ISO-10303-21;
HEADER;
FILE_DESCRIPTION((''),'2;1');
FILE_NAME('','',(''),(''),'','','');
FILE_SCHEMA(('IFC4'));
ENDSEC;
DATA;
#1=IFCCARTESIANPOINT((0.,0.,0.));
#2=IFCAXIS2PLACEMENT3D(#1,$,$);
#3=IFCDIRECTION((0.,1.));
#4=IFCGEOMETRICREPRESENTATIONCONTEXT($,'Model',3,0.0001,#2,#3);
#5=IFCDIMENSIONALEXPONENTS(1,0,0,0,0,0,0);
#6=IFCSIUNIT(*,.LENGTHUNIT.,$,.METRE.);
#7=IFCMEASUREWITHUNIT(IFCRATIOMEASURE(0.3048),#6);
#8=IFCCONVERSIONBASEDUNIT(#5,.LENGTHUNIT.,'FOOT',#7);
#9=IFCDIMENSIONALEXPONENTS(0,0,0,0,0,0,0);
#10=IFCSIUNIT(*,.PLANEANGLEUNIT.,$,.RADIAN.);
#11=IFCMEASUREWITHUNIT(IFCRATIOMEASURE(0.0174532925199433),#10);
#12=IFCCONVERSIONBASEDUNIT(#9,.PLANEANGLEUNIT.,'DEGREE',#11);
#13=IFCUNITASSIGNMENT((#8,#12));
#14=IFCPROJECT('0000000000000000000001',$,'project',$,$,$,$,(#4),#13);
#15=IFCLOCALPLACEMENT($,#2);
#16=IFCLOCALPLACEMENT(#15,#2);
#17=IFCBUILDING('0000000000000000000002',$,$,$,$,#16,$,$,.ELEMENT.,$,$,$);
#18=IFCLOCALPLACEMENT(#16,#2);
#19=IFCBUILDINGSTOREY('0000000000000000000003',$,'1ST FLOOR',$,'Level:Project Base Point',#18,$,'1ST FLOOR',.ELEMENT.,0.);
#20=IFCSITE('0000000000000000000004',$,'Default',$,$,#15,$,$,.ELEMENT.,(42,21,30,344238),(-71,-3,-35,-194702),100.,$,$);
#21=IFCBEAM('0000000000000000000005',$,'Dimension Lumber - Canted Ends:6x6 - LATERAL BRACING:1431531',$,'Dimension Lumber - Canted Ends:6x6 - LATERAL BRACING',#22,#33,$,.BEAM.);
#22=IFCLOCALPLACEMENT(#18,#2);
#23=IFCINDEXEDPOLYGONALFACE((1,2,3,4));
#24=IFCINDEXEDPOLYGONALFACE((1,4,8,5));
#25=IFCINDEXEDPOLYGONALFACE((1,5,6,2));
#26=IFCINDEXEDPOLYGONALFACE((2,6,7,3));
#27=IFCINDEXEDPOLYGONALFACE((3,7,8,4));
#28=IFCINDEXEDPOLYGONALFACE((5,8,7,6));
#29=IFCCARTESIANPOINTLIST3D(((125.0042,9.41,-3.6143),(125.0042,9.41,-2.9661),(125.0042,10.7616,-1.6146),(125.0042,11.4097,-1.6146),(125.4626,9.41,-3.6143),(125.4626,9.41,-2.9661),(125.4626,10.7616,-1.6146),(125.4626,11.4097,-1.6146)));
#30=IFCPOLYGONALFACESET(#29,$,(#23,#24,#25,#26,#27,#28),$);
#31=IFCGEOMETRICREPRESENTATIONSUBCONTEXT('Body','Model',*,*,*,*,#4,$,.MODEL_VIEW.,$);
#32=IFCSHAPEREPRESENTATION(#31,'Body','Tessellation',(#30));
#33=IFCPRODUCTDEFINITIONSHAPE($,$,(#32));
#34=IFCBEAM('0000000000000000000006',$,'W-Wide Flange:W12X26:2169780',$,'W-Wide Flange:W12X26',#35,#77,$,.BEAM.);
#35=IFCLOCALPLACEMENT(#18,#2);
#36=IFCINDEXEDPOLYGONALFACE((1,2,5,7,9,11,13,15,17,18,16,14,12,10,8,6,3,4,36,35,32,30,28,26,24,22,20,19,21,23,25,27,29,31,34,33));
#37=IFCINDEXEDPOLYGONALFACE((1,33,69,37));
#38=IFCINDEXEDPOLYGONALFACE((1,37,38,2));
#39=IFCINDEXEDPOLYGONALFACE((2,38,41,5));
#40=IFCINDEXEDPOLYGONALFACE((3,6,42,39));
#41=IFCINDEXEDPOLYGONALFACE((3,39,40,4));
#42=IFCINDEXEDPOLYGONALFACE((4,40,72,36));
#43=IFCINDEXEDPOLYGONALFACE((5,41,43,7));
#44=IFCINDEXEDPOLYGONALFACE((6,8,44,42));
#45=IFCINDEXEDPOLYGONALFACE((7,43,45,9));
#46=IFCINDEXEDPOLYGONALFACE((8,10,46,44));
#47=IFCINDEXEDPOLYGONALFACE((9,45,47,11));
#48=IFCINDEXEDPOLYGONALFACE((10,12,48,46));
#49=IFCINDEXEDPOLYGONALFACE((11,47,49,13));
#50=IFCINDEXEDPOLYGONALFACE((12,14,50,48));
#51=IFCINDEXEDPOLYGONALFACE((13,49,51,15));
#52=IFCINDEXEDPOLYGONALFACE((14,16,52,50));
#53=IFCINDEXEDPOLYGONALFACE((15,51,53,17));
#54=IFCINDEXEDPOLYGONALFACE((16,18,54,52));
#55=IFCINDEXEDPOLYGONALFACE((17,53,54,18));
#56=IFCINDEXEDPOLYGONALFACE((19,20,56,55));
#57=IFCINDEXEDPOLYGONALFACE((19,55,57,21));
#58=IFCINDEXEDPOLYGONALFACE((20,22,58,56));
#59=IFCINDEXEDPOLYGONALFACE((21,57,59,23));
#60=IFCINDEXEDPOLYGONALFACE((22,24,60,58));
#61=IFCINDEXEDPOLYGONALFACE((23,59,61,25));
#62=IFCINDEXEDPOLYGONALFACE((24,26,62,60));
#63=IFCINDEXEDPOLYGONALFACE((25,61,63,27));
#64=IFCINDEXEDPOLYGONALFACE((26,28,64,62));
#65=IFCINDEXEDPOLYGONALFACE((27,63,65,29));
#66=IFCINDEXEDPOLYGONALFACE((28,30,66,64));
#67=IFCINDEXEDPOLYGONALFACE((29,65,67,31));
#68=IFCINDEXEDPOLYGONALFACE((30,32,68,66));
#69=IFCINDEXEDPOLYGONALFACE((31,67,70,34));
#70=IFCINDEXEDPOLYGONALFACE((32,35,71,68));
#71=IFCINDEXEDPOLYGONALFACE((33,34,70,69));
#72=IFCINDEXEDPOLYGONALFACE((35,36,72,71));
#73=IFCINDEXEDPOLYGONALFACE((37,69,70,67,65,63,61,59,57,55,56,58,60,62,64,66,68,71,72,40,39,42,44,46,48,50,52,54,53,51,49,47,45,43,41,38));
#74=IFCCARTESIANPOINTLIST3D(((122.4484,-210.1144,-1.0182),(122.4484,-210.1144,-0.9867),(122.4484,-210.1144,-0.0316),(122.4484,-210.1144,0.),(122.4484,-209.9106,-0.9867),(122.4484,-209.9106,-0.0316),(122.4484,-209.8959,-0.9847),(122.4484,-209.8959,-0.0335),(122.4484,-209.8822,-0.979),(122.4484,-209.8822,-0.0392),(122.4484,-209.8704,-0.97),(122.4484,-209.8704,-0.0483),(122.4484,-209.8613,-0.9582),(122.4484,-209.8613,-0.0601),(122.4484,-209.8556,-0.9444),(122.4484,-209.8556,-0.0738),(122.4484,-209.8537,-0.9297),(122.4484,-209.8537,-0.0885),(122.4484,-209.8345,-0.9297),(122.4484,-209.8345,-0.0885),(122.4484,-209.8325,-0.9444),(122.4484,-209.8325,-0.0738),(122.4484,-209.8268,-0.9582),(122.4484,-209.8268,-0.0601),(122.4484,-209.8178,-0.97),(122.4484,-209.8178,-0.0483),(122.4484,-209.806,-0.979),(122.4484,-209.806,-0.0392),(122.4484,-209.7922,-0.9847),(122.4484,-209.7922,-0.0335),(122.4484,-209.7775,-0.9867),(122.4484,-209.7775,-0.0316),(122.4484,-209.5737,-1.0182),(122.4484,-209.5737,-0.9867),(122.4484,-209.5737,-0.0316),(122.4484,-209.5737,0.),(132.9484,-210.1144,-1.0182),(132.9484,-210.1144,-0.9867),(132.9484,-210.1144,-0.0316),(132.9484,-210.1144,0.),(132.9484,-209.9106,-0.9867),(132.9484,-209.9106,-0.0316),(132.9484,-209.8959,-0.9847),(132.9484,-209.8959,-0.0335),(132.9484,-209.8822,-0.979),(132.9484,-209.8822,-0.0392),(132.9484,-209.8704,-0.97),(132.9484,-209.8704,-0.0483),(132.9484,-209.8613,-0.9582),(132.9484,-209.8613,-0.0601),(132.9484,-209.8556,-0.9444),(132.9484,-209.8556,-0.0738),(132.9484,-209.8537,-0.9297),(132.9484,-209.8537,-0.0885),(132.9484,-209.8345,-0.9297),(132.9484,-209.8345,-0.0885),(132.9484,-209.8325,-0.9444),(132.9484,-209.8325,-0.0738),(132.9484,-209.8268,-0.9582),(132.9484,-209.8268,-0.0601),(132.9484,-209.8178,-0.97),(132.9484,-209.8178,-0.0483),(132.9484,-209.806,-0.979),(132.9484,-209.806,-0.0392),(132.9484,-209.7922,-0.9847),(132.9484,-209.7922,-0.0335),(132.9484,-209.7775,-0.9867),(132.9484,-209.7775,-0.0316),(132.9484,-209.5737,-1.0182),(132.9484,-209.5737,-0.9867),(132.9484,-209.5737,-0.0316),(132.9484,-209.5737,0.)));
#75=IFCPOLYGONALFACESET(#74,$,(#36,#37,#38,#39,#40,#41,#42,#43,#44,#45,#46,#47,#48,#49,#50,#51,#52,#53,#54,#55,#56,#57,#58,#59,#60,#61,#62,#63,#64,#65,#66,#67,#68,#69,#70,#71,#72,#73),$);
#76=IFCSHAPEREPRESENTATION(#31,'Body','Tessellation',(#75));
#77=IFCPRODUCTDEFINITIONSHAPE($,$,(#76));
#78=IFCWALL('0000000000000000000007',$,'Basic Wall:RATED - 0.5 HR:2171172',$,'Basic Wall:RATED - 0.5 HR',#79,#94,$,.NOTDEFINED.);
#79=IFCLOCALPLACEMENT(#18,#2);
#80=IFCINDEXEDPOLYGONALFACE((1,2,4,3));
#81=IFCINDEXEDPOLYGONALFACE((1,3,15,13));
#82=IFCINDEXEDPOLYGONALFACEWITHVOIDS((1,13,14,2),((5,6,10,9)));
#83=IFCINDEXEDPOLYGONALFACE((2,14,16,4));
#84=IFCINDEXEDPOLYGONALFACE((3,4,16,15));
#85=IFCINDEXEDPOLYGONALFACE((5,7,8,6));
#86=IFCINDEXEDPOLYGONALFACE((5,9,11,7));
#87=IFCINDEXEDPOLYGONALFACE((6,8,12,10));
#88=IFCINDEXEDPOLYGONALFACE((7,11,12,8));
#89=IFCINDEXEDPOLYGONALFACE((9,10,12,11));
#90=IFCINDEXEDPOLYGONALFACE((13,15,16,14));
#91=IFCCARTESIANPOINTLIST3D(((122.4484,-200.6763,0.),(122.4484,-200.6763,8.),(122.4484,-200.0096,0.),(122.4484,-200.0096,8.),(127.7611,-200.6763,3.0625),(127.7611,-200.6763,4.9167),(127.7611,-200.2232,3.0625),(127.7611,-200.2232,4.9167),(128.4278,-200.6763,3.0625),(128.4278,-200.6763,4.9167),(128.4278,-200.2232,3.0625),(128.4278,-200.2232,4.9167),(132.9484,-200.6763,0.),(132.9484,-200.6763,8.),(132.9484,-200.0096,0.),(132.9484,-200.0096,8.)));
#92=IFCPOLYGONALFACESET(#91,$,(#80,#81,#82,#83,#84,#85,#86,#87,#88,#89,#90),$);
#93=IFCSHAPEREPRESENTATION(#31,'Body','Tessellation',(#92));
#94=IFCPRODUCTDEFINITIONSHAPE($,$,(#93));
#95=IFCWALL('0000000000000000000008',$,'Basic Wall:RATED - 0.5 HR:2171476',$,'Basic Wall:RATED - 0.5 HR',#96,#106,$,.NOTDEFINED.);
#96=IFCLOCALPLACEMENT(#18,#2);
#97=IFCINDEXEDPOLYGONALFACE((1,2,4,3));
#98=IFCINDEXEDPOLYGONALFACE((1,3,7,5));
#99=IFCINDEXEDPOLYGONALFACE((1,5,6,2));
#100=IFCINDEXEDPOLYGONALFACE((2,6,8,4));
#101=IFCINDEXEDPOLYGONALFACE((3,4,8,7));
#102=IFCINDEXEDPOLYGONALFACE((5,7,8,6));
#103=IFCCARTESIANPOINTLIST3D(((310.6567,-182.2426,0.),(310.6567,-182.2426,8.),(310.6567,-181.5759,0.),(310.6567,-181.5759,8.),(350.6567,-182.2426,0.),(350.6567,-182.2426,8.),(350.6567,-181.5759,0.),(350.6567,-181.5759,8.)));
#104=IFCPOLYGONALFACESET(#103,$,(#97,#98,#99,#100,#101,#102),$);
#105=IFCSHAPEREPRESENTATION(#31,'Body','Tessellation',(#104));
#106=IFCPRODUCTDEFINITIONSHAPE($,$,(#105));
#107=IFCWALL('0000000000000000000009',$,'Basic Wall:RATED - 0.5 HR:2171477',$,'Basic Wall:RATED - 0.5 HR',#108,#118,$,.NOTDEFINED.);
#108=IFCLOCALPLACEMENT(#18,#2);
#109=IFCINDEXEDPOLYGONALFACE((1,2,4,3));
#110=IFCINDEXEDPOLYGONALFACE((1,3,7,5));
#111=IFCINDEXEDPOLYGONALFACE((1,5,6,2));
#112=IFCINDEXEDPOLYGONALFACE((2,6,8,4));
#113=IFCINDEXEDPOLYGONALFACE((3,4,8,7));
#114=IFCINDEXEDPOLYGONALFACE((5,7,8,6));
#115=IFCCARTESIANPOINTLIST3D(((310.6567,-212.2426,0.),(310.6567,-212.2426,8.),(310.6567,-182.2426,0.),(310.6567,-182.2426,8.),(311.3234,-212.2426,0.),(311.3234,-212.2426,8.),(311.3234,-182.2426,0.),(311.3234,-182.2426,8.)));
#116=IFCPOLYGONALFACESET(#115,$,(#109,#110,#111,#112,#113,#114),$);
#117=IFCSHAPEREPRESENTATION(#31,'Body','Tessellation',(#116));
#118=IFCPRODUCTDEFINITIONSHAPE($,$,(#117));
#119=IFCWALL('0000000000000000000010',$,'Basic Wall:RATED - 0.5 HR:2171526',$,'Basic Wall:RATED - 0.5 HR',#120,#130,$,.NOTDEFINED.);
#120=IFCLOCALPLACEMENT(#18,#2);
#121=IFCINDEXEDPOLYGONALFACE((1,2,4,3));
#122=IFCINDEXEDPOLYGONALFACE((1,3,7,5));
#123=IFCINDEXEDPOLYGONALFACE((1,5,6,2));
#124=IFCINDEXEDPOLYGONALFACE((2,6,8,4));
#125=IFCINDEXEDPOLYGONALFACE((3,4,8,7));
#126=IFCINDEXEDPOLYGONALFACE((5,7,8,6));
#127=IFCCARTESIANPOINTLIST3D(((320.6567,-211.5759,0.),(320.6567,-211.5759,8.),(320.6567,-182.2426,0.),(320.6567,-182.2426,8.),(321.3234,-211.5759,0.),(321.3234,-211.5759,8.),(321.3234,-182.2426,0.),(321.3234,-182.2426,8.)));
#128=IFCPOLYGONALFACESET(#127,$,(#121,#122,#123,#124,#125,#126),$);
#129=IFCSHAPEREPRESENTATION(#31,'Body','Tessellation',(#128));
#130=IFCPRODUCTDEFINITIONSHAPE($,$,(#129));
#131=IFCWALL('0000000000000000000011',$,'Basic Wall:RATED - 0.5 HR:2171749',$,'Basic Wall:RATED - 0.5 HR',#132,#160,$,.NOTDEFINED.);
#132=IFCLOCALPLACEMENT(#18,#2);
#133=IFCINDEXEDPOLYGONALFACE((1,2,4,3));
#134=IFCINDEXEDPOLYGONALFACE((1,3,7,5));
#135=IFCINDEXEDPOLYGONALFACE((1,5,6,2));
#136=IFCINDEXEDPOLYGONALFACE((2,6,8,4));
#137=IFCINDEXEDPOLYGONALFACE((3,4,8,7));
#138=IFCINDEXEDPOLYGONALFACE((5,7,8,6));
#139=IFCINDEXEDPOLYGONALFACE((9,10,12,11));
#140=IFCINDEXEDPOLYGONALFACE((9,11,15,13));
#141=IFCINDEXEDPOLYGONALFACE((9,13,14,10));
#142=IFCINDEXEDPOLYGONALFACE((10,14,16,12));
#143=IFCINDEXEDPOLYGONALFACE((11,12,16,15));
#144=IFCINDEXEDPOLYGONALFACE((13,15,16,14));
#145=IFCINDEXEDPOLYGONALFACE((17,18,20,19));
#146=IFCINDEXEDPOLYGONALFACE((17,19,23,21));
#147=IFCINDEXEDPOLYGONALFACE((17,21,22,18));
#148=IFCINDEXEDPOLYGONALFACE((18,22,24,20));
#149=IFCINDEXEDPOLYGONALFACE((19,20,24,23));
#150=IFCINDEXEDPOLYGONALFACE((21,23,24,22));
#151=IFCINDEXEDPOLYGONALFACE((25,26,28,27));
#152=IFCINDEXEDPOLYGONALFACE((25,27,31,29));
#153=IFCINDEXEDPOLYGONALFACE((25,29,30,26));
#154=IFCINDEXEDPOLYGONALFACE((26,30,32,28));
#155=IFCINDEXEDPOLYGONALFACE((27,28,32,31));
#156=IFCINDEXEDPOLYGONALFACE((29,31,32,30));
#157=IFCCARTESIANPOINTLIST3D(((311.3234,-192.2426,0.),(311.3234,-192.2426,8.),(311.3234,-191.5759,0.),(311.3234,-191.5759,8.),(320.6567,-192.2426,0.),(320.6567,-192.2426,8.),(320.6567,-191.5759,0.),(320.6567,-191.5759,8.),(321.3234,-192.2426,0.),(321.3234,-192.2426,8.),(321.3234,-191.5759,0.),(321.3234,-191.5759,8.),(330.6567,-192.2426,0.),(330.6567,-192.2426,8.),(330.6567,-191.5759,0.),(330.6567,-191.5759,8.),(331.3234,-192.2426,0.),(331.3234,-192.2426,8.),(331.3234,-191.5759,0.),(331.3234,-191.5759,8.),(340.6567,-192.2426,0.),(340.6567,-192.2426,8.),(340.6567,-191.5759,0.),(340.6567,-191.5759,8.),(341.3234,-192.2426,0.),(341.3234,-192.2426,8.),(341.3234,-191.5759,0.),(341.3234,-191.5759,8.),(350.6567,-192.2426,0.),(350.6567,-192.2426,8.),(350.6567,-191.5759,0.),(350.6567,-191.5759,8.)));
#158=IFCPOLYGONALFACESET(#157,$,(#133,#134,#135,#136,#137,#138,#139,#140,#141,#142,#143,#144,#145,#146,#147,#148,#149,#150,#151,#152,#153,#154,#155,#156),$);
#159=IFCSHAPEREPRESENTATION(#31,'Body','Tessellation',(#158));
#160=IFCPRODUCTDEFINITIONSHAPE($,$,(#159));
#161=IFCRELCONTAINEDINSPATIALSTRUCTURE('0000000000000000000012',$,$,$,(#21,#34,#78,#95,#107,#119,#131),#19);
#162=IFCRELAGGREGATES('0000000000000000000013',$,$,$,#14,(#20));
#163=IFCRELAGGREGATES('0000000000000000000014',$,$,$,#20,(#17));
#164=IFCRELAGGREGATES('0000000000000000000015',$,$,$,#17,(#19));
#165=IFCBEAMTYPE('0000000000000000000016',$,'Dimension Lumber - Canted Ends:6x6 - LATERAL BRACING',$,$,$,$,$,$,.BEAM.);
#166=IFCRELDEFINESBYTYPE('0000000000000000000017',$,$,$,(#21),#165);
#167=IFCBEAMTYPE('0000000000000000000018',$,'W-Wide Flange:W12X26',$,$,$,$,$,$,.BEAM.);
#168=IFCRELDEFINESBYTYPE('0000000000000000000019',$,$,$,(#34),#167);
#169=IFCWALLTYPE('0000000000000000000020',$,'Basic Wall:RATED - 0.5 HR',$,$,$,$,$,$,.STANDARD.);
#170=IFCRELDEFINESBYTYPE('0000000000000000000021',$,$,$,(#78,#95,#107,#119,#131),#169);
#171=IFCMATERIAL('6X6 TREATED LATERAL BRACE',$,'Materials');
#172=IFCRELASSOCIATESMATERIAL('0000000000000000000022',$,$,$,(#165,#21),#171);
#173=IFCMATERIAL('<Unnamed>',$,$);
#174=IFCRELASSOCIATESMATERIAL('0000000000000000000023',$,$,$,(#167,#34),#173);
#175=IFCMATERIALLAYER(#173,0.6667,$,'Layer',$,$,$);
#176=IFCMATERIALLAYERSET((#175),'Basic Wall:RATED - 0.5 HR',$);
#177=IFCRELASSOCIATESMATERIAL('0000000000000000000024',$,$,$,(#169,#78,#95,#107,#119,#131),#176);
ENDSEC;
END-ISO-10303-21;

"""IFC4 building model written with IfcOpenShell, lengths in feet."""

from ifc_helpers import new_model, entity, si_unit, converted_unit, direction, frame, frame_2d, origin, origin_2d_with_axis, place, context, subcontext, project, spatial, rectangle, i_section, extrude, clip, halfspace, source, transform, mapped, material, layer, layer_set, layer_usage, material_profile, profile_set, profile_usage, type_object, type_shapes, element, save


model = new_model("IFC4")

# Units and contexts
model_context = context("Model", 3, precision=0.0001, world=origin(), true_north=direction((0.0, 1.0)))
body_context = subcontext(model_context, "Body", "Model", "MODEL_VIEW")
ifc_project = project(units=[converted_unit("LENGTHUNIT", "FOOT", entity("IfcRatioMeasure", 0.3048), si_unit("LENGTHUNIT", "METRE"), dimensions=[1, 0, 0, 0, 0, 0, 0]), converted_unit("PLANEANGLEUNIT", "DEGREE", entity("IfcRatioMeasure", 0.0174532925199433), si_unit("PLANEANGLEUNIT", "RADIAN"), dimensions=[0, 0, 0, 0, 0, 0, 0])], contexts=[model_context])

# Site, building, storey
site_placement = place(None, origin())
site = spatial("IfcSite", under=ifc_project, at=site_placement, Name="Default", CompositionType="ELEMENT", RefLatitude=(42, 21, 30, 344238), RefLongitude=(-71, -3, -35, -194702), RefElevation=100.0)
building_placement = place(site_placement, origin())
building = spatial("IfcBuilding", under=site, at=building_placement, CompositionType="ELEMENT")
storey_placement = place(building_placement, origin())
storey = spatial("IfcBuildingStorey", under=building, at=storey_placement, Name="1ST FLOOR", ObjectType="Level:Project Base Point", LongName="1ST FLOOR", CompositionType="ELEMENT", Elevation=0.0)

# Beams
ifc_material_1 = material(Name="6X6 TREATED LATERAL BRACE", Category="Materials")
ifc_material_profile_1 = material_profile(ifc_material_1, rectangle(XDim=0.4583, YDim=0.4583, at=origin_2d_with_axis()), Name="6x6 - LATERAL BRACING")
ifc_profile_set_1 = profile_set([ifc_material_profile_1], Name="6x6 - LATERAL BRACING")
beam_type_1 = type_object("IfcBeamType", Name="Dimension Lumber - Canted Ends:6x6 - LATERAL BRACING", PredefinedType="BEAM", material=ifc_profile_set_1)
shared_shape_1 = source(origin(), body_context, "Body", "Clipping", [
    clip(clip(extrude(rectangle(XDim=0.4583, YDim=0.4583, at=frame_2d((0.0, 0.0), x_axis=(1.0, 0.0))), frame((-1.414, 0.0, 0.0), z_axis=(1.0, 0.0, 0.0), x_axis=(0.0, 0.0, -1.0)), (0.0, 0.0, 1.0), 2.828), halfspace(frame((-0.9557, -0.2292, 0.2292), z_axis=(-0.707107, 0.0, 0.707107), x_axis=(0.0, 1.0, 0.0)), False)), halfspace(frame((1.414, -0.2292, -0.2292), z_axis=(0.707107, 0.0, 0.707107), x_axis=(0.0, 1.0, 0.0)), False)),
])
type_shapes(beam_type_1, [shared_shape_1])
ifc_profile_usage_1 = profile_usage(ifc_profile_set_1, cardinal=2)
beam_1_placement = place(storey_placement, frame((125.2334, 10.2478, -2.4524), z_axis=(0.0, -0.707107, 0.707107), x_axis=(0.0, -0.707107, -0.707107)))
element("IfcBeam", 1, at=beam_1_placement, inside=storey, type_object=beam_type_1, material=ifc_profile_usage_1, Name="Dimension Lumber - Canted Ends:6x6 - LATERAL BRACING:1431531", ObjectType="Dimension Lumber - Canted Ends:6x6 - LATERAL BRACING", PredefinedType="BEAM", context=body_context, shape_type="MappedRepresentation", body=[
    mapped(shared_shape_1, transform((0.0, 0.0, 0.0), scale=1.0)),
])
ifc_material_2 = material(Name="<Unnamed>")
ifc_material_profile_2 = material_profile(ifc_material_2, i_section(OverallWidth=0.5407, OverallDepth=1.0182, WebThickness=0.0192, FlangeThickness=0.0316, FilletRadius=0.057, at=frame_2d((0.0, 0.0), x_axis=(0.0, 1.0))), Name="W12X26")
ifc_profile_set_2 = profile_set([ifc_material_profile_2], Name="W12X26")
ifc_profile_usage_2 = profile_usage(ifc_profile_set_2, cardinal=8)
beam_type_2 = type_object("IfcBeamType", Name="W-Wide Flange:W12X26", PredefinedType="BEAM", material=ifc_profile_set_2)
shared_shape_2 = source(origin(), body_context, "Body", "SweptSolid", [
    extrude(i_section(OverallWidth=0.5407, OverallDepth=1.0182, WebThickness=0.0192, FlangeThickness=0.0316, FilletRadius=0.057, at=frame_2d((0.0, 0.0), x_axis=(0.0, 1.0))), frame((-5.25, 0.0, 0.0), z_axis=(1.0, 0.0, 0.0), x_axis=(0.0, 0.0, -1.0)), (0.0, 0.0, 1.0), 10.5),
])
type_shapes(beam_type_2, [shared_shape_2])
beam_2_placement = place(storey_placement, frame((127.6984, -209.8441, -0.5091)))
element("IfcBeam", 2, at=beam_2_placement, inside=storey, type_object=beam_type_2, material=ifc_profile_usage_2, Name="W-Wide Flange:W12X26:2169780", ObjectType="W-Wide Flange:W12X26", PredefinedType="BEAM", context=body_context, shape_type="MappedRepresentation", body=[
    mapped(shared_shape_2, transform((0.0, 0.0, 0.0), scale=1.0)),
])

# Wall, opening
ifc_layer = layer(ifc_material_2, 0.6667, Name="Layer")
ifc_layer_set = layer_set([ifc_layer], Name="Basic Wall:RATED - 0.5 HR")
ifc_layer_usage_1 = layer_usage(ifc_layer_set, "AXIS2", "NEGATIVE", 0.3333)
wall_type = type_object("IfcWallType", Name="Basic Wall:RATED - 0.5 HR", PredefinedType="STANDARD", material=ifc_layer_set)
wall_1_placement = place(storey_placement, frame((122.4484, -200.3429, 0.0)))
wall_1 = element("IfcWall", 3, at=wall_1_placement, inside=storey, type_object=wall_type, material=ifc_layer_usage_1, Name="Basic Wall:RATED - 0.5 HR:2171172", ObjectType="Basic Wall:RATED - 0.5 HR", PredefinedType="NOTDEFINED", context=body_context, shape_type="SweptSolid", body=[
    extrude(rectangle(XDim=10.5, YDim=0.6667, at=frame_2d((5.25, 0.0), x_axis=(-1.0, 0.0))), origin(), (0.0, 0.0, 1.0), 8.0),
])
opening_1_placement = place(wall_1_placement, frame((5.3127, -0.3542, 3.0625)))
element("IfcOpeningElement", 4, at=opening_1_placement, cuts=wall_1, PredefinedType="RECESS", context=body_context, shape_type="SweptSolid", body=[
    extrude(rectangle(XDim=1.8542, YDim=0.6667, at=frame_2d((0.0, 0.0), x_axis=(1.0, 0.0))), frame((0.3333, 0.0, 0.9271), z_axis=(0.0, 1.0, 0.0), x_axis=(0.0, 0.0, -1.0)), (0.0, 0.0, 1.0), 0.474),
])

# Walls
ifc_layer_usage_2 = layer_usage(ifc_layer_set, "AXIS2", "NEGATIVE", 0.3333)
wall_2_placement = place(storey_placement, frame((310.6567, -181.9092, 0.0)))
element("IfcWall", 5, at=wall_2_placement, inside=storey, type_object=wall_type, material=ifc_layer_usage_2, Name="Basic Wall:RATED - 0.5 HR:2171476", ObjectType="Basic Wall:RATED - 0.5 HR", PredefinedType="NOTDEFINED", context=body_context, shape_type="SweptSolid", body=[
    extrude(rectangle(XDim=40.0, YDim=0.6667, at=frame_2d((20.0, 0.0), x_axis=(-1.0, 0.0))), origin(), (0.0, 0.0, 1.0), 8.0),
])
ifc_layer_usage_3 = layer_usage(ifc_layer_set, "AXIS2", "NEGATIVE", 0.3333)
wall_3_placement = place(storey_placement, frame((310.9901, -212.2426, 0.0), z_axis=(0.0, 0.0, 1.0), x_axis=(0.0, 1.0, 0.0)))
element("IfcWall", 6, at=wall_3_placement, inside=storey, type_object=wall_type, material=ifc_layer_usage_3, Name="Basic Wall:RATED - 0.5 HR:2171477", ObjectType="Basic Wall:RATED - 0.5 HR", PredefinedType="NOTDEFINED", context=body_context, shape_type="SweptSolid", body=[
    extrude(rectangle(XDim=30.0, YDim=0.6667, at=frame_2d((15.0, 0.0), x_axis=(-1.0, 0.0))), origin(), (0.0, 0.0, 1.0), 8.0),
])
ifc_layer_usage_4 = layer_usage(ifc_layer_set, "AXIS2", "NEGATIVE", 0.3333)
wall_4_placement = place(storey_placement, frame((320.9901, -182.2426, 0.0), z_axis=(0.0, 0.0, 1.0), x_axis=(0.0, -1.0, 0.0)))
element("IfcWall", 7, at=wall_4_placement, inside=storey, type_object=wall_type, material=ifc_layer_usage_4, Name="Basic Wall:RATED - 0.5 HR:2171526", ObjectType="Basic Wall:RATED - 0.5 HR", PredefinedType="NOTDEFINED", context=body_context, shape_type="SweptSolid", body=[
    extrude(rectangle(XDim=29.3333, YDim=0.6667, at=frame_2d((14.6667, 0.0), x_axis=(-1.0, 0.0))), origin(), (0.0, 0.0, 1.0), 8.0),
])

# Wall, openings
ifc_layer_usage_5 = layer_usage(ifc_layer_set, "AXIS2", "NEGATIVE", 0.3333)
wall_5_placement = place(storey_placement, frame((311.3234, -191.9092, 0.0)))
wall_5 = element("IfcWall", 8, at=wall_5_placement, inside=storey, type_object=wall_type, material=ifc_layer_usage_5, Name="Basic Wall:RATED - 0.5 HR:2171749", ObjectType="Basic Wall:RATED - 0.5 HR", PredefinedType="NOTDEFINED", context=body_context, shape_type="SweptSolid", body=[
    extrude(rectangle(XDim=39.3333, YDim=0.6667, at=frame_2d((19.6667, 0.0), x_axis=(-1.0, 0.0))), origin(), (0.0, 0.0, 1.0), 8.0),
])
opening_2_placement = place(storey_placement, frame((311.3234, -191.9092, 0.0)))
element("IfcOpeningElement", 9, at=opening_2_placement, cuts=wall_5, PredefinedType="OPENING", context=body_context, shape_type="SweptSolid", body=[
    extrude(rectangle(XDim=8.0, YDim=0.6667, at=frame_2d((0.0, 0.0), x_axis=(1.0, 0.0))), frame((29.3333, 0.0, 4.0), z_axis=(1.0, 0.0, 0.0), x_axis=(0.0, 0.0, -1.0)), (0.0, 0.0, 1.0), 0.6667),
])
opening_3_placement = place(storey_placement, frame((311.3234, -191.9092, 0.0)))
element("IfcOpeningElement", 10, at=opening_3_placement, cuts=wall_5, PredefinedType="OPENING", context=body_context, shape_type="SweptSolid", body=[
    extrude(rectangle(XDim=8.0, YDim=0.6667, at=frame_2d((0.0, 0.0), x_axis=(1.0, 0.0))), frame((19.3333, 0.0, 4.0), z_axis=(1.0, 0.0, 0.0), x_axis=(0.0, 0.0, -1.0)), (0.0, 0.0, 1.0), 0.6667),
])
opening_4_placement = place(storey_placement, frame((311.3234, -191.9092, 0.0)))
element("IfcOpeningElement", 11, at=opening_4_placement, cuts=wall_5, PredefinedType="OPENING", context=body_context, shape_type="SweptSolid", body=[
    extrude(rectangle(XDim=8.0, YDim=0.6667, at=frame_2d((0.0, 0.0), x_axis=(1.0, 0.0))), frame((9.3333, 0.0, 4.0), z_axis=(1.0, 0.0, 0.0), x_axis=(0.0, 0.0, -1.0)), (0.0, 0.0, 1.0), 0.6667),
])

save(model, "model.ifc")
